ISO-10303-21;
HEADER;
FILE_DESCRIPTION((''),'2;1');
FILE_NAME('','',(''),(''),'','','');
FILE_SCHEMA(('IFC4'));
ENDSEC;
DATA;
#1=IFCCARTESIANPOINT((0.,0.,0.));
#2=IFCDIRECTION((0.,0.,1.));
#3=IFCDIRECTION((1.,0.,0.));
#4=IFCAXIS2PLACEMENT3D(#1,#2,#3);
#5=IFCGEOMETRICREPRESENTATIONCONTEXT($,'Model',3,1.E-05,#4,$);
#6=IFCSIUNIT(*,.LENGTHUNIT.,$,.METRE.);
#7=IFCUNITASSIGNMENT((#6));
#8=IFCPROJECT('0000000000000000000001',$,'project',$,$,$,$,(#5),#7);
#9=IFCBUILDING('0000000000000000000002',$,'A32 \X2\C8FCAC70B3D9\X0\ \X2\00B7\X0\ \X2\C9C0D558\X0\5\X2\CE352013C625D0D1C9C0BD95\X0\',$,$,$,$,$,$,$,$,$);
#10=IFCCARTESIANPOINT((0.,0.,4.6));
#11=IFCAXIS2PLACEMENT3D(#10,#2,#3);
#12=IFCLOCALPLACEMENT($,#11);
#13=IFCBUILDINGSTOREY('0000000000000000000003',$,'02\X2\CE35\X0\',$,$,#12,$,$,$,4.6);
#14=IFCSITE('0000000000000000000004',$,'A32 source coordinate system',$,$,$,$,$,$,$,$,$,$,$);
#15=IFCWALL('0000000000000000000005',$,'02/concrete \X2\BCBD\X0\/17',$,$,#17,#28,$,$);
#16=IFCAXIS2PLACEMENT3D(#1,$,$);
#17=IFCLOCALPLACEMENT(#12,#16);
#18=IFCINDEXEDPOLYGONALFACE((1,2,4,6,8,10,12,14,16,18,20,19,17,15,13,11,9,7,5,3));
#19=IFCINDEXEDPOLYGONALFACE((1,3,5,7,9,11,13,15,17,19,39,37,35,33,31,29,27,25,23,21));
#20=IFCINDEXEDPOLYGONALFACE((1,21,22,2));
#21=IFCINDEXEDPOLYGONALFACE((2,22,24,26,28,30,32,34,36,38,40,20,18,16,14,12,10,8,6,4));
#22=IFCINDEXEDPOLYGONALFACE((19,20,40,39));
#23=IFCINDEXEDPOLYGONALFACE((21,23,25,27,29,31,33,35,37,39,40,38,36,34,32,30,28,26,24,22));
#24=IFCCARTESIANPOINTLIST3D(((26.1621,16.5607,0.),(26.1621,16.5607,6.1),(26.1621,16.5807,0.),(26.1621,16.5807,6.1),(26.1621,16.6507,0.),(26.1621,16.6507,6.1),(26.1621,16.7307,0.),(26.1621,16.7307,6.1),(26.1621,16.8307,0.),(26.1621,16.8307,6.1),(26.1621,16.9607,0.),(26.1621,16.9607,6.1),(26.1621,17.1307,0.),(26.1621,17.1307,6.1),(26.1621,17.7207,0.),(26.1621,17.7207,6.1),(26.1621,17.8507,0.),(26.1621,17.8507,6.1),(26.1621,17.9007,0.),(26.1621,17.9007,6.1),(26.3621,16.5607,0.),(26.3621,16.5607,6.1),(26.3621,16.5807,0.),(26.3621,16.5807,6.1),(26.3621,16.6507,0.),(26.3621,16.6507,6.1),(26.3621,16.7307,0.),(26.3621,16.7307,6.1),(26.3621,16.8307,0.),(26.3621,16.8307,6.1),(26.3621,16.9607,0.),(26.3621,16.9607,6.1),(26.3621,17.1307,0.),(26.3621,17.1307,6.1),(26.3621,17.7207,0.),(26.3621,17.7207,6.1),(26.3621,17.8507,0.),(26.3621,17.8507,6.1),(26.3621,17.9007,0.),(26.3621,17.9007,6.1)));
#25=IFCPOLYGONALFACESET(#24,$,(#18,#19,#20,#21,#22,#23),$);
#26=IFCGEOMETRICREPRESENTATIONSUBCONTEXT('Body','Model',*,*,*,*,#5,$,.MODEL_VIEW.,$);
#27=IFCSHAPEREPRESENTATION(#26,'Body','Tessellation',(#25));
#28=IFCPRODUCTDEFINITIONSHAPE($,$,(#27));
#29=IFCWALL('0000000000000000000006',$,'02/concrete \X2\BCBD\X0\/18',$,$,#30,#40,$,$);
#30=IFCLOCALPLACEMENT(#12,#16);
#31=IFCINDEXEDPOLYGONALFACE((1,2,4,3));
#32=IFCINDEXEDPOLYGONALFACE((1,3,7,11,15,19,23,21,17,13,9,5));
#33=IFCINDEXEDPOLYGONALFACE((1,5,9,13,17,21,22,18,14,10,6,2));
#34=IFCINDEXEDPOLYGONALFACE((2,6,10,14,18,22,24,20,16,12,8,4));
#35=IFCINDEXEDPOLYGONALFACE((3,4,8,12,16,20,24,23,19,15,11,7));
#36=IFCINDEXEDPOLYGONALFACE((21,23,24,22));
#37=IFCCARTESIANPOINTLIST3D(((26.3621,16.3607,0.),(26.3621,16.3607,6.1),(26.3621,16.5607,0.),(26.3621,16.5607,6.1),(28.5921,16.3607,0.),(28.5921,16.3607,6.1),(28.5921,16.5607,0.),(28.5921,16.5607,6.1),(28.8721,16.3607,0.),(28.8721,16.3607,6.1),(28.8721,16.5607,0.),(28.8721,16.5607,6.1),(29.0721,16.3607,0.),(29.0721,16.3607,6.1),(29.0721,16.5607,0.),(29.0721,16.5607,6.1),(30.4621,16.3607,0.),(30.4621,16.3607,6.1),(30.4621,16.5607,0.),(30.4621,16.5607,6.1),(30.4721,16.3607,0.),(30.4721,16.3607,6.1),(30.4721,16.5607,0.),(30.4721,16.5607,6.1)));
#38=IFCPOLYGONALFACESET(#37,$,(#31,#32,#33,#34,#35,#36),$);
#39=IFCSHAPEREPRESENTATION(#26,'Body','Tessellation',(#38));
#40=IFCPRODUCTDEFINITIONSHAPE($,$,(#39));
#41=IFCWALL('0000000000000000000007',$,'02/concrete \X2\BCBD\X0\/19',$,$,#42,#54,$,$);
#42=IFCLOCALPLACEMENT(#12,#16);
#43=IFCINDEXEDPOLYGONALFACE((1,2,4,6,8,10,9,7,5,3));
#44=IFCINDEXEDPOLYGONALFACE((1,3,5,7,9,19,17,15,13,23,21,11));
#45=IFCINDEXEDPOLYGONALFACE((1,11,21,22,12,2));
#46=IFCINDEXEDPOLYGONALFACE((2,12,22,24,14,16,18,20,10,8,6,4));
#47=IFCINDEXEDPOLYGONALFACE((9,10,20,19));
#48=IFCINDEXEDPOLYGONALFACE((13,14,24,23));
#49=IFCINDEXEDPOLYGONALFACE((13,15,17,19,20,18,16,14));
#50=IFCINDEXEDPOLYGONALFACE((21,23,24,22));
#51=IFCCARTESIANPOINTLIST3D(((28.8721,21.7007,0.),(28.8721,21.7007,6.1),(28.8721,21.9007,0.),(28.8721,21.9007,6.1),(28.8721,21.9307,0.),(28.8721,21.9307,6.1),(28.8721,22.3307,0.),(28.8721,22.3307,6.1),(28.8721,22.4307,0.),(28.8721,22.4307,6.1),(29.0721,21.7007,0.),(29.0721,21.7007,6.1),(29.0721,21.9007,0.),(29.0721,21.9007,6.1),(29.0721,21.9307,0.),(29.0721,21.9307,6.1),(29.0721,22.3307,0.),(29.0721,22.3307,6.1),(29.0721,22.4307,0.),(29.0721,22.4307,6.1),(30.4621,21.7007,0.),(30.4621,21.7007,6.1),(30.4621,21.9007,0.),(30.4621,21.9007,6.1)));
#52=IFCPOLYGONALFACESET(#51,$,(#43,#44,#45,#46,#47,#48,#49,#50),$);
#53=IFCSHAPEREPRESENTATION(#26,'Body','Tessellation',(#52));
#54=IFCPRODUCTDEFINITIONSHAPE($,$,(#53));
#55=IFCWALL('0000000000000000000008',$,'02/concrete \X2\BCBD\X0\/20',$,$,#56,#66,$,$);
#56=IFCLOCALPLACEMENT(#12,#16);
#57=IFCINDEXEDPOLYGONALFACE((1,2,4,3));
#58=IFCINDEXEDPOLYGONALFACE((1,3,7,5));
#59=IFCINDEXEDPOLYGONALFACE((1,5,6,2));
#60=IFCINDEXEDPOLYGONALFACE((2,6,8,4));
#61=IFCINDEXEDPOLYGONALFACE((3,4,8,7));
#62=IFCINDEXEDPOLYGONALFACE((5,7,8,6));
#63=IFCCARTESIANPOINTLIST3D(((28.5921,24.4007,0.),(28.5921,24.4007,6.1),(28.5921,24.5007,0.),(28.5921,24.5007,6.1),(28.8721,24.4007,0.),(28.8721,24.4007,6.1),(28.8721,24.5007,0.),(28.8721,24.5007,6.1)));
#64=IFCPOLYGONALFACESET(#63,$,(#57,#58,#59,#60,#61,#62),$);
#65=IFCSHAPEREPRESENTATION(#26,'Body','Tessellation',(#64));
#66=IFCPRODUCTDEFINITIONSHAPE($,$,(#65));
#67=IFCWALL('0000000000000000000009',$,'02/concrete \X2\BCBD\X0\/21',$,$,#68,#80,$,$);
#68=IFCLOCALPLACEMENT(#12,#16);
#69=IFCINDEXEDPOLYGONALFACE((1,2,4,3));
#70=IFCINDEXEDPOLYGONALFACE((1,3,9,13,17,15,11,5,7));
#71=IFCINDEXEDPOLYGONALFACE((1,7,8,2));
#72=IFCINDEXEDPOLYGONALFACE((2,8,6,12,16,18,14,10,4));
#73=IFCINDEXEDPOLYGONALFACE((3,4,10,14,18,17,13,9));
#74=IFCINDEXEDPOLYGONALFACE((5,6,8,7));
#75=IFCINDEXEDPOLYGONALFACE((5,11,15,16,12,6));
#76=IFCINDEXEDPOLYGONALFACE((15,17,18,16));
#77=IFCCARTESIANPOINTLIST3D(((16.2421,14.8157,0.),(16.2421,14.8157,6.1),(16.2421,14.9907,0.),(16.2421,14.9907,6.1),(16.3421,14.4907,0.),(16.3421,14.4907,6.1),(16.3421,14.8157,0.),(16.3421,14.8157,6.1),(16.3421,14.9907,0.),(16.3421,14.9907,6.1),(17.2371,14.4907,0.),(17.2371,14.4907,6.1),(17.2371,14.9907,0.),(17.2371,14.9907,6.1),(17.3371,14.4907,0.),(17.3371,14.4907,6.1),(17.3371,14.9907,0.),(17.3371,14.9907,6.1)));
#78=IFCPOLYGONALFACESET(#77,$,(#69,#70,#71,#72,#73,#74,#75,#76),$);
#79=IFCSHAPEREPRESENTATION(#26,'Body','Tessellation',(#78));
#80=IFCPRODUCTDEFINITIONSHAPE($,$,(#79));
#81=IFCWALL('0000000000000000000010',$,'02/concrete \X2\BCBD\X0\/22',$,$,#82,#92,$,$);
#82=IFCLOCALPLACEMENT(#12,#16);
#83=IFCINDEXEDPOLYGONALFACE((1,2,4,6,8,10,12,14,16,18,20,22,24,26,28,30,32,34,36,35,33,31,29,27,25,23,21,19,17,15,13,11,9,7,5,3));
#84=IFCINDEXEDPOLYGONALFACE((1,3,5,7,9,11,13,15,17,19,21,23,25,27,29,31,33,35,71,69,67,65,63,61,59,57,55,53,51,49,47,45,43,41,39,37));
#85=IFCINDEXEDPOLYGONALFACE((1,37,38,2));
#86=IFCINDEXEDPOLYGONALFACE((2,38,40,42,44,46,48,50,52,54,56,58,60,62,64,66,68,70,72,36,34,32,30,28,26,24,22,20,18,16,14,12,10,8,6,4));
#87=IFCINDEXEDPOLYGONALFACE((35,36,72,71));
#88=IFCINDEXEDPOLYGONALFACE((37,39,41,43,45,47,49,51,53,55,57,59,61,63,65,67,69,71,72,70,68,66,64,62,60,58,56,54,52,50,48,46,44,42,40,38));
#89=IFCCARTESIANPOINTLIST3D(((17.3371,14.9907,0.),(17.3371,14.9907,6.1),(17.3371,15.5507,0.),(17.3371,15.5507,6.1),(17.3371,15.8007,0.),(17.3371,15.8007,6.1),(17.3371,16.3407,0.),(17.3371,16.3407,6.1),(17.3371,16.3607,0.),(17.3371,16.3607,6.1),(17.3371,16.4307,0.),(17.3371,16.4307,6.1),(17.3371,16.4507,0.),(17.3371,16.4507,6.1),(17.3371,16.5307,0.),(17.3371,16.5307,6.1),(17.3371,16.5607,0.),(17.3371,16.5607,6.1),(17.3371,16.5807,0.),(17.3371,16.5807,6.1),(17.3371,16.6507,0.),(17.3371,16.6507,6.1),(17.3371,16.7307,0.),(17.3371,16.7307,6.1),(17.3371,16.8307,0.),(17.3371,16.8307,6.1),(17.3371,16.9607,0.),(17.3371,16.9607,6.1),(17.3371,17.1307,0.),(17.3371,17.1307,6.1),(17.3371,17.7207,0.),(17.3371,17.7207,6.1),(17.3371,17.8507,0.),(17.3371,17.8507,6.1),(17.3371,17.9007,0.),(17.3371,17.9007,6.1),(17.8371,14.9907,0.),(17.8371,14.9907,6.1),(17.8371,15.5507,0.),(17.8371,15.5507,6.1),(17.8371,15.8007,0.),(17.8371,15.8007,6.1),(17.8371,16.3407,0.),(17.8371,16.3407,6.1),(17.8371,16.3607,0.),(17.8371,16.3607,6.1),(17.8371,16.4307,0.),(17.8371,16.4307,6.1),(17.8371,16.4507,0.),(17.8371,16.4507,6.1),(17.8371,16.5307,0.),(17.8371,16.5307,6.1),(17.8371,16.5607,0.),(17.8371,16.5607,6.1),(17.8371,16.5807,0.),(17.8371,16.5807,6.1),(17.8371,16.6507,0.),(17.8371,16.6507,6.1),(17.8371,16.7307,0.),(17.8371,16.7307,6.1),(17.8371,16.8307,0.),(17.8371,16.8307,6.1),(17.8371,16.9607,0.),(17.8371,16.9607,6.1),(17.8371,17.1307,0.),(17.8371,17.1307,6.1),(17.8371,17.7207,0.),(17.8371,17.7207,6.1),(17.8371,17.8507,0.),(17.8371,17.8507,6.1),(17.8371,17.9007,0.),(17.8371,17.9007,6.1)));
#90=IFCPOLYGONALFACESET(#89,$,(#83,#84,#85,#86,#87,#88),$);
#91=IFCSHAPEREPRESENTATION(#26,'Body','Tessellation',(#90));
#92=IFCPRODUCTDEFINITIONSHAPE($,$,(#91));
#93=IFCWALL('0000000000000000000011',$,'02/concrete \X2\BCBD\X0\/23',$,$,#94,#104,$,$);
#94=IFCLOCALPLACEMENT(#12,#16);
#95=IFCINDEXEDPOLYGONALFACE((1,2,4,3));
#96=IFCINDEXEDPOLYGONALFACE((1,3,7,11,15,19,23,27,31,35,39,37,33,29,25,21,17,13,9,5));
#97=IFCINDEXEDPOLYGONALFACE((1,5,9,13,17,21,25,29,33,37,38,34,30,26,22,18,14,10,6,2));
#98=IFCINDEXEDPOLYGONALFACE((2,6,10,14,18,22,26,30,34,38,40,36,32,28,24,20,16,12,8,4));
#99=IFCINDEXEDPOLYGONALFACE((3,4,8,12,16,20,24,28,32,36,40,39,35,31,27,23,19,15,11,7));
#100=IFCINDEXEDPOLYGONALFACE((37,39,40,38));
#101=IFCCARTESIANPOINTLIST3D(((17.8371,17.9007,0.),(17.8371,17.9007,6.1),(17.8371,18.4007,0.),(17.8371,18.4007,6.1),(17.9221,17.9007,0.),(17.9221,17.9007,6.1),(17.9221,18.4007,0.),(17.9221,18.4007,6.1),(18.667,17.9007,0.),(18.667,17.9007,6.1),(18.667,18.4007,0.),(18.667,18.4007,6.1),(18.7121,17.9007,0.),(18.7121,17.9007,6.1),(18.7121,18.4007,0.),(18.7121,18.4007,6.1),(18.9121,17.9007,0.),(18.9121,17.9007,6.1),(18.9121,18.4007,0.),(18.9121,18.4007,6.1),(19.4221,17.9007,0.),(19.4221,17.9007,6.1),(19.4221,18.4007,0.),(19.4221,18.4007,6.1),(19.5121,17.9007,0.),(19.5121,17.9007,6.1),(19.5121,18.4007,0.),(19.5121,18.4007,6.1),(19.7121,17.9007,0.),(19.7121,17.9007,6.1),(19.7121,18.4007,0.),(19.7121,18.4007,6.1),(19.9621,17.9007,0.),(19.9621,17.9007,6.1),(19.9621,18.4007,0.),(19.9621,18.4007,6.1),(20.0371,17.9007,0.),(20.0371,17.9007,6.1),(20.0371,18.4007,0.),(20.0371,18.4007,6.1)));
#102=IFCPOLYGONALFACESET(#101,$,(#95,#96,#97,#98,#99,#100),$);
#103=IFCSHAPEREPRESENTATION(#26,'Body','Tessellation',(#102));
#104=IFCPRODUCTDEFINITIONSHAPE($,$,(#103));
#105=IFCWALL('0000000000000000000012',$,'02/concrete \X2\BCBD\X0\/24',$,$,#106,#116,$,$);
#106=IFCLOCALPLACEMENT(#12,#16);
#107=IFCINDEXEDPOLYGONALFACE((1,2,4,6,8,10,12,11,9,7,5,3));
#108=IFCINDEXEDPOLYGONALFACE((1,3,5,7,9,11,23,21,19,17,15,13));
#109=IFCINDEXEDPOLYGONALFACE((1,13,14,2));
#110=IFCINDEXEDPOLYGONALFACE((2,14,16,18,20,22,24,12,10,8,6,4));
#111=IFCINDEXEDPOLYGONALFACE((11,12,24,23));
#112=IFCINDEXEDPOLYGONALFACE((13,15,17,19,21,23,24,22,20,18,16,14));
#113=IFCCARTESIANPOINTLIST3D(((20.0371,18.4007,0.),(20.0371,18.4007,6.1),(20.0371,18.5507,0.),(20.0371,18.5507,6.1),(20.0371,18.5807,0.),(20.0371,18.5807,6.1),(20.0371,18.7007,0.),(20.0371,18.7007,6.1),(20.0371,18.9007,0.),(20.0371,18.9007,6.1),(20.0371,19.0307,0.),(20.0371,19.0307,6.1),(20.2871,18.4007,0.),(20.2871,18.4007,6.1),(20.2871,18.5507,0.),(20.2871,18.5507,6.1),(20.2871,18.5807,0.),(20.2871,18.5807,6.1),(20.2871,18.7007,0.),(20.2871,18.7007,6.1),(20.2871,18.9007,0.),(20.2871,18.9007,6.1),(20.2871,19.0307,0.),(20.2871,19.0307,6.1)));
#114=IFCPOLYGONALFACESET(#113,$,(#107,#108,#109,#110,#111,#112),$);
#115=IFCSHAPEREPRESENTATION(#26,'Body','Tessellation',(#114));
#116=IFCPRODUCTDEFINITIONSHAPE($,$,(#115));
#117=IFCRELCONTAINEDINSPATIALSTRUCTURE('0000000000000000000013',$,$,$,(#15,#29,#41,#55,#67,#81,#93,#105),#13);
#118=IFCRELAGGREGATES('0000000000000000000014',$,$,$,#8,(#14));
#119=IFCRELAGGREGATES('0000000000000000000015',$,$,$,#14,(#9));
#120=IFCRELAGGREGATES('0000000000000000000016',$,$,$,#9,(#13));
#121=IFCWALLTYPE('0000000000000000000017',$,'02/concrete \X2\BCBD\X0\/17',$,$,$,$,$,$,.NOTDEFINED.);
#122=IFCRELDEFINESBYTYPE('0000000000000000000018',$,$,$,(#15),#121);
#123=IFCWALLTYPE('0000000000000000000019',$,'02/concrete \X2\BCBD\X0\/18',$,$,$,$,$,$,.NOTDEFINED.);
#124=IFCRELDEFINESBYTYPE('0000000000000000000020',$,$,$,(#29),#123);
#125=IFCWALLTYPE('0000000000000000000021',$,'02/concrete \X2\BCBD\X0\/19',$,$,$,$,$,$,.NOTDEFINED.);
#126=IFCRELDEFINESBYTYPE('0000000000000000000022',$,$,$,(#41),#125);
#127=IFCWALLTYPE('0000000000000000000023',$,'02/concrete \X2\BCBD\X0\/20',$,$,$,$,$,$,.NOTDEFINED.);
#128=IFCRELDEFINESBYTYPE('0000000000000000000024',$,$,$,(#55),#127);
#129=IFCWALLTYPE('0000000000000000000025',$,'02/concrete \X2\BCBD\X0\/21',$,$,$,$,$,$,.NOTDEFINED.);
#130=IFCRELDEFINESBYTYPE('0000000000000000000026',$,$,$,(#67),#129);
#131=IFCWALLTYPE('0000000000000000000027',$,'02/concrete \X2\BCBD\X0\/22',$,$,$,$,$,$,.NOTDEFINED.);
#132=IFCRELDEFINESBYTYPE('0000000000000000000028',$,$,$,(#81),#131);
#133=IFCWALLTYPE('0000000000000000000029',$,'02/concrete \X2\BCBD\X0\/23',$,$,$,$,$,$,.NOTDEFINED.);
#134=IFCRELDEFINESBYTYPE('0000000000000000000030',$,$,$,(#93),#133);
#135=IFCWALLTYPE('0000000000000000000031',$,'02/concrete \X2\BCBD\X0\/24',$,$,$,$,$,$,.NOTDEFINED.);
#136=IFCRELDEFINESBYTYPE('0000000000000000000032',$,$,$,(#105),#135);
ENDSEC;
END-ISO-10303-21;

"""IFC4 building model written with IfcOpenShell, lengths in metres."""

from ifc_helpers import new_model, si_unit, frame, origin, origin_with_axes, place, context, subcontext, project, spatial, polyline, outline, extrude, source, transform, mapped, type_object, type_shapes, element, save


model = new_model("IFC4")

# Units and contexts
model_context = context("Model", 3, precision=1e-05, world=origin_with_axes())
body_context = subcontext(model_context, "Body", "Model", "MODEL_VIEW")
ifc_project = project(units=[si_unit("LENGTHUNIT", "METRE")], contexts=[model_context])

# Site, building, storey
site = spatial("IfcSite", under=ifc_project, Name="A32 source coordinate system")
building = spatial("IfcBuilding", under=site, Name="A32 주거동 · 지하5층–옥탑지붕")
storey_placement = place(None, frame((0.0, 0.0, 4.6), z_axis=(0.0, 0.0, 1.0), x_axis=(1.0, 0.0, 0.0)))
storey = spatial("IfcBuildingStorey", under=building, at=storey_placement, Name="02층", Elevation=4.6)

# Walls
wall_type_1 = type_object("IfcWallType", Name="02/concrete 벽/17", PredefinedType="NOTDEFINED")
shared_shape_1 = source(origin(), body_context, "Body", "SweptSolid", [
    extrude(outline(polyline([(26.3621, 17.8507), (26.3621, 17.7207), (26.3621, 17.1307), (26.3621, 16.9607), (26.3621, 16.8307), (26.3621, 16.7307), (26.3621, 16.6507), (26.3621, 16.5807), (26.3621, 16.5607), (26.1621, 16.5607), (26.1621, 16.5807), (26.1621, 16.6507), (26.1621, 16.7307), (26.1621, 16.8307), (26.1621, 16.9607), (26.1621, 17.1307), (26.1621, 17.7207), (26.1621, 17.8507), (26.1621, 17.9007), (26.3621, 17.9007), (26.3621, 17.8507)])), origin(), (0.0, 0.0, 1.0), 6.1),
])
type_shapes(wall_type_1, [shared_shape_1])
wall_1_placement = place(storey_placement, origin_with_axes())
element("IfcWall", 1, at=wall_1_placement, inside=storey, type_object=wall_type_1, Name="02/concrete 벽/17", context=body_context, shape_type="MappedRepresentation", body=[
    mapped(shared_shape_1, transform((0.0, 0.0, 0.0), scale=1.0)),
])
wall_type_2 = type_object("IfcWallType", Name="02/concrete 벽/18", PredefinedType="NOTDEFINED")
shared_shape_2 = source(origin(), body_context, "Body", "SweptSolid", [
    extrude(outline(polyline([(29.0721, 16.5607), (30.4621, 16.5607), (30.4721, 16.5607), (30.4721, 16.3607), (30.4621, 16.3607), (29.0721, 16.3607), (28.8721, 16.3607), (28.5921, 16.3607), (26.3621, 16.3607), (26.3621, 16.5607), (28.5921, 16.5607), (28.8721, 16.5607), (29.0721, 16.5607)])), origin(), (0.0, 0.0, 1.0), 6.1),
])
type_shapes(wall_type_2, [shared_shape_2])
wall_2_placement = place(storey_placement, origin_with_axes())
element("IfcWall", 2, at=wall_2_placement, inside=storey, type_object=wall_type_2, Name="02/concrete 벽/18", context=body_context, shape_type="MappedRepresentation", body=[
    mapped(shared_shape_2, transform((0.0, 0.0, 0.0), scale=1.0)),
])
wall_type_3 = type_object("IfcWallType", Name="02/concrete 벽/19", PredefinedType="NOTDEFINED")
shared_shape_3 = source(origin(), body_context, "Body", "SweptSolid", [
    extrude(outline(polyline([(29.0721, 22.3307), (29.0721, 21.9307), (29.0721, 21.9007), (30.4621, 21.9007), (30.4621, 21.7007), (29.0721, 21.7007), (28.8721, 21.7007), (28.8721, 21.9007), (28.8721, 21.9307), (28.8721, 22.3307), (28.8721, 22.4307), (29.0721, 22.4307), (29.0721, 22.3307)])), origin(), (0.0, 0.0, 1.0), 6.1),
])
type_shapes(wall_type_3, [shared_shape_3])
wall_3_placement = place(storey_placement, origin_with_axes())
element("IfcWall", 3, at=wall_3_placement, inside=storey, type_object=wall_type_3, Name="02/concrete 벽/19", context=body_context, shape_type="MappedRepresentation", body=[
    mapped(shared_shape_3, transform((0.0, 0.0, 0.0), scale=1.0)),
])
wall_type_4 = type_object("IfcWallType", Name="02/concrete 벽/20", PredefinedType="NOTDEFINED")
shared_shape_4 = source(origin(), body_context, "Body", "SweptSolid", [
    extrude(outline(polyline([(28.5921, 24.4007), (28.5921, 24.5007), (28.8721, 24.5007), (28.8721, 24.4007), (28.5921, 24.4007)])), origin(), (0.0, 0.0, 1.0), 6.1),
])
type_shapes(wall_type_4, [shared_shape_4])
wall_4_placement = place(storey_placement, origin_with_axes())
element("IfcWall", 4, at=wall_4_placement, inside=storey, type_object=wall_type_4, Name="02/concrete 벽/20", context=body_context, shape_type="MappedRepresentation", body=[
    mapped(shared_shape_4, transform((0.0, 0.0, 0.0), scale=1.0)),
])
wall_type_5 = type_object("IfcWallType", Name="02/concrete 벽/21", PredefinedType="NOTDEFINED")
shared_shape_5 = source(origin(), body_context, "Body", "SweptSolid", [
    extrude(outline(polyline([(16.2421, 14.9907), (16.3421, 14.9907), (17.2371, 14.9907), (17.3371, 14.9907), (17.3371, 14.4907), (17.2371, 14.4907), (16.3421, 14.4907), (16.3421, 14.8157), (16.2421, 14.8157), (16.2421, 14.9907)])), origin(), (0.0, 0.0, 1.0), 6.1),
])
type_shapes(wall_type_5, [shared_shape_5])
wall_5_placement = place(storey_placement, origin_with_axes())
element("IfcWall", 5, at=wall_5_placement, inside=storey, type_object=wall_type_5, Name="02/concrete 벽/21", context=body_context, shape_type="MappedRepresentation", body=[
    mapped(shared_shape_5, transform((0.0, 0.0, 0.0), scale=1.0)),
])
wall_type_6 = type_object("IfcWallType", Name="02/concrete 벽/22", PredefinedType="NOTDEFINED")
shared_shape_6 = source(origin(), body_context, "Body", "SweptSolid", [
    extrude(outline(polyline([(17.3371, 16.3407), (17.3371, 16.3607), (17.3371, 16.4307), (17.3371, 16.4507), (17.3371, 16.5307), (17.3371, 16.5607), (17.3371, 16.5807), (17.3371, 16.6507), (17.3371, 16.7307), (17.3371, 16.8307), (17.3371, 16.9607), (17.3371, 17.1307), (17.3371, 17.7207), (17.3371, 17.8507), (17.3371, 17.9007), (17.8371, 17.9007), (17.8371, 17.8507), (17.8371, 17.7207), (17.8371, 17.1307), (17.8371, 16.9607), (17.8371, 16.8307), (17.8371, 16.7307), (17.8371, 16.6507), (17.8371, 16.5807), (17.8371, 16.5607), (17.8371, 16.5307), (17.8371, 16.4507), (17.8371, 16.4307), (17.8371, 16.3607), (17.8371, 16.3407), (17.8371, 15.8007), (17.8371, 15.5507), (17.8371, 14.9907), (17.3371, 14.9907), (17.3371, 15.5507), (17.3371, 15.8007), (17.3371, 16.3407)])), origin(), (0.0, 0.0, 1.0), 6.1),
])
type_shapes(wall_type_6, [shared_shape_6])
wall_6_placement = place(storey_placement, origin_with_axes())
element("IfcWall", 6, at=wall_6_placement, inside=storey, type_object=wall_type_6, Name="02/concrete 벽/22", context=body_context, shape_type="MappedRepresentation", body=[
    mapped(shared_shape_6, transform((0.0, 0.0, 0.0), scale=1.0)),
])
wall_type_7 = type_object("IfcWallType", Name="02/concrete 벽/23", PredefinedType="NOTDEFINED")
shared_shape_7 = source(origin(), body_context, "Body", "SweptSolid", [
    extrude(outline(polyline([(18.667, 18.4007), (18.7121, 18.4007), (18.9121, 18.4007), (19.4221, 18.4007), (19.5121, 18.4007), (19.7121, 18.4007), (19.9621, 18.4007), (20.0371, 18.4007), (20.0371, 17.9007), (19.9621, 17.9007), (19.7121, 17.9007), (19.5121, 17.9007), (19.4221, 17.9007), (18.9121, 17.9007), (18.7121, 17.9007), (18.667, 17.9007), (17.9221, 17.9007), (17.8371, 17.9007), (17.8371, 18.4007), (17.9221, 18.4007), (18.667, 18.4007)])), origin(), (0.0, 0.0, 1.0), 6.1),
])
type_shapes(wall_type_7, [shared_shape_7])
wall_7_placement = place(storey_placement, origin_with_axes())
element("IfcWall", 7, at=wall_7_placement, inside=storey, type_object=wall_type_7, Name="02/concrete 벽/23", context=body_context, shape_type="MappedRepresentation", body=[
    mapped(shared_shape_7, transform((0.0, 0.0, 0.0), scale=1.0)),
])
wall_type_8 = type_object("IfcWallType", Name="02/concrete 벽/24", PredefinedType="NOTDEFINED")
shared_shape_8 = source(origin(), body_context, "Body", "SweptSolid", [
    extrude(outline(polyline([(20.0371, 18.7007), (20.0371, 18.9007), (20.0371, 19.0307), (20.2871, 19.0307), (20.2871, 18.9007), (20.2871, 18.7007), (20.2871, 18.5807), (20.2871, 18.5507), (20.2871, 18.4007), (20.0371, 18.4007), (20.0371, 18.5507), (20.0371, 18.5807), (20.0371, 18.7007)])), origin(), (0.0, 0.0, 1.0), 6.1),
])
type_shapes(wall_type_8, [shared_shape_8])
wall_8_placement = place(storey_placement, origin_with_axes())
element("IfcWall", 8, at=wall_8_placement, inside=storey, type_object=wall_type_8, Name="02/concrete 벽/24", context=body_context, shape_type="MappedRepresentation", body=[
    mapped(shared_shape_8, transform((0.0, 0.0, 0.0), scale=1.0)),
])

save(model, "model.ifc")
